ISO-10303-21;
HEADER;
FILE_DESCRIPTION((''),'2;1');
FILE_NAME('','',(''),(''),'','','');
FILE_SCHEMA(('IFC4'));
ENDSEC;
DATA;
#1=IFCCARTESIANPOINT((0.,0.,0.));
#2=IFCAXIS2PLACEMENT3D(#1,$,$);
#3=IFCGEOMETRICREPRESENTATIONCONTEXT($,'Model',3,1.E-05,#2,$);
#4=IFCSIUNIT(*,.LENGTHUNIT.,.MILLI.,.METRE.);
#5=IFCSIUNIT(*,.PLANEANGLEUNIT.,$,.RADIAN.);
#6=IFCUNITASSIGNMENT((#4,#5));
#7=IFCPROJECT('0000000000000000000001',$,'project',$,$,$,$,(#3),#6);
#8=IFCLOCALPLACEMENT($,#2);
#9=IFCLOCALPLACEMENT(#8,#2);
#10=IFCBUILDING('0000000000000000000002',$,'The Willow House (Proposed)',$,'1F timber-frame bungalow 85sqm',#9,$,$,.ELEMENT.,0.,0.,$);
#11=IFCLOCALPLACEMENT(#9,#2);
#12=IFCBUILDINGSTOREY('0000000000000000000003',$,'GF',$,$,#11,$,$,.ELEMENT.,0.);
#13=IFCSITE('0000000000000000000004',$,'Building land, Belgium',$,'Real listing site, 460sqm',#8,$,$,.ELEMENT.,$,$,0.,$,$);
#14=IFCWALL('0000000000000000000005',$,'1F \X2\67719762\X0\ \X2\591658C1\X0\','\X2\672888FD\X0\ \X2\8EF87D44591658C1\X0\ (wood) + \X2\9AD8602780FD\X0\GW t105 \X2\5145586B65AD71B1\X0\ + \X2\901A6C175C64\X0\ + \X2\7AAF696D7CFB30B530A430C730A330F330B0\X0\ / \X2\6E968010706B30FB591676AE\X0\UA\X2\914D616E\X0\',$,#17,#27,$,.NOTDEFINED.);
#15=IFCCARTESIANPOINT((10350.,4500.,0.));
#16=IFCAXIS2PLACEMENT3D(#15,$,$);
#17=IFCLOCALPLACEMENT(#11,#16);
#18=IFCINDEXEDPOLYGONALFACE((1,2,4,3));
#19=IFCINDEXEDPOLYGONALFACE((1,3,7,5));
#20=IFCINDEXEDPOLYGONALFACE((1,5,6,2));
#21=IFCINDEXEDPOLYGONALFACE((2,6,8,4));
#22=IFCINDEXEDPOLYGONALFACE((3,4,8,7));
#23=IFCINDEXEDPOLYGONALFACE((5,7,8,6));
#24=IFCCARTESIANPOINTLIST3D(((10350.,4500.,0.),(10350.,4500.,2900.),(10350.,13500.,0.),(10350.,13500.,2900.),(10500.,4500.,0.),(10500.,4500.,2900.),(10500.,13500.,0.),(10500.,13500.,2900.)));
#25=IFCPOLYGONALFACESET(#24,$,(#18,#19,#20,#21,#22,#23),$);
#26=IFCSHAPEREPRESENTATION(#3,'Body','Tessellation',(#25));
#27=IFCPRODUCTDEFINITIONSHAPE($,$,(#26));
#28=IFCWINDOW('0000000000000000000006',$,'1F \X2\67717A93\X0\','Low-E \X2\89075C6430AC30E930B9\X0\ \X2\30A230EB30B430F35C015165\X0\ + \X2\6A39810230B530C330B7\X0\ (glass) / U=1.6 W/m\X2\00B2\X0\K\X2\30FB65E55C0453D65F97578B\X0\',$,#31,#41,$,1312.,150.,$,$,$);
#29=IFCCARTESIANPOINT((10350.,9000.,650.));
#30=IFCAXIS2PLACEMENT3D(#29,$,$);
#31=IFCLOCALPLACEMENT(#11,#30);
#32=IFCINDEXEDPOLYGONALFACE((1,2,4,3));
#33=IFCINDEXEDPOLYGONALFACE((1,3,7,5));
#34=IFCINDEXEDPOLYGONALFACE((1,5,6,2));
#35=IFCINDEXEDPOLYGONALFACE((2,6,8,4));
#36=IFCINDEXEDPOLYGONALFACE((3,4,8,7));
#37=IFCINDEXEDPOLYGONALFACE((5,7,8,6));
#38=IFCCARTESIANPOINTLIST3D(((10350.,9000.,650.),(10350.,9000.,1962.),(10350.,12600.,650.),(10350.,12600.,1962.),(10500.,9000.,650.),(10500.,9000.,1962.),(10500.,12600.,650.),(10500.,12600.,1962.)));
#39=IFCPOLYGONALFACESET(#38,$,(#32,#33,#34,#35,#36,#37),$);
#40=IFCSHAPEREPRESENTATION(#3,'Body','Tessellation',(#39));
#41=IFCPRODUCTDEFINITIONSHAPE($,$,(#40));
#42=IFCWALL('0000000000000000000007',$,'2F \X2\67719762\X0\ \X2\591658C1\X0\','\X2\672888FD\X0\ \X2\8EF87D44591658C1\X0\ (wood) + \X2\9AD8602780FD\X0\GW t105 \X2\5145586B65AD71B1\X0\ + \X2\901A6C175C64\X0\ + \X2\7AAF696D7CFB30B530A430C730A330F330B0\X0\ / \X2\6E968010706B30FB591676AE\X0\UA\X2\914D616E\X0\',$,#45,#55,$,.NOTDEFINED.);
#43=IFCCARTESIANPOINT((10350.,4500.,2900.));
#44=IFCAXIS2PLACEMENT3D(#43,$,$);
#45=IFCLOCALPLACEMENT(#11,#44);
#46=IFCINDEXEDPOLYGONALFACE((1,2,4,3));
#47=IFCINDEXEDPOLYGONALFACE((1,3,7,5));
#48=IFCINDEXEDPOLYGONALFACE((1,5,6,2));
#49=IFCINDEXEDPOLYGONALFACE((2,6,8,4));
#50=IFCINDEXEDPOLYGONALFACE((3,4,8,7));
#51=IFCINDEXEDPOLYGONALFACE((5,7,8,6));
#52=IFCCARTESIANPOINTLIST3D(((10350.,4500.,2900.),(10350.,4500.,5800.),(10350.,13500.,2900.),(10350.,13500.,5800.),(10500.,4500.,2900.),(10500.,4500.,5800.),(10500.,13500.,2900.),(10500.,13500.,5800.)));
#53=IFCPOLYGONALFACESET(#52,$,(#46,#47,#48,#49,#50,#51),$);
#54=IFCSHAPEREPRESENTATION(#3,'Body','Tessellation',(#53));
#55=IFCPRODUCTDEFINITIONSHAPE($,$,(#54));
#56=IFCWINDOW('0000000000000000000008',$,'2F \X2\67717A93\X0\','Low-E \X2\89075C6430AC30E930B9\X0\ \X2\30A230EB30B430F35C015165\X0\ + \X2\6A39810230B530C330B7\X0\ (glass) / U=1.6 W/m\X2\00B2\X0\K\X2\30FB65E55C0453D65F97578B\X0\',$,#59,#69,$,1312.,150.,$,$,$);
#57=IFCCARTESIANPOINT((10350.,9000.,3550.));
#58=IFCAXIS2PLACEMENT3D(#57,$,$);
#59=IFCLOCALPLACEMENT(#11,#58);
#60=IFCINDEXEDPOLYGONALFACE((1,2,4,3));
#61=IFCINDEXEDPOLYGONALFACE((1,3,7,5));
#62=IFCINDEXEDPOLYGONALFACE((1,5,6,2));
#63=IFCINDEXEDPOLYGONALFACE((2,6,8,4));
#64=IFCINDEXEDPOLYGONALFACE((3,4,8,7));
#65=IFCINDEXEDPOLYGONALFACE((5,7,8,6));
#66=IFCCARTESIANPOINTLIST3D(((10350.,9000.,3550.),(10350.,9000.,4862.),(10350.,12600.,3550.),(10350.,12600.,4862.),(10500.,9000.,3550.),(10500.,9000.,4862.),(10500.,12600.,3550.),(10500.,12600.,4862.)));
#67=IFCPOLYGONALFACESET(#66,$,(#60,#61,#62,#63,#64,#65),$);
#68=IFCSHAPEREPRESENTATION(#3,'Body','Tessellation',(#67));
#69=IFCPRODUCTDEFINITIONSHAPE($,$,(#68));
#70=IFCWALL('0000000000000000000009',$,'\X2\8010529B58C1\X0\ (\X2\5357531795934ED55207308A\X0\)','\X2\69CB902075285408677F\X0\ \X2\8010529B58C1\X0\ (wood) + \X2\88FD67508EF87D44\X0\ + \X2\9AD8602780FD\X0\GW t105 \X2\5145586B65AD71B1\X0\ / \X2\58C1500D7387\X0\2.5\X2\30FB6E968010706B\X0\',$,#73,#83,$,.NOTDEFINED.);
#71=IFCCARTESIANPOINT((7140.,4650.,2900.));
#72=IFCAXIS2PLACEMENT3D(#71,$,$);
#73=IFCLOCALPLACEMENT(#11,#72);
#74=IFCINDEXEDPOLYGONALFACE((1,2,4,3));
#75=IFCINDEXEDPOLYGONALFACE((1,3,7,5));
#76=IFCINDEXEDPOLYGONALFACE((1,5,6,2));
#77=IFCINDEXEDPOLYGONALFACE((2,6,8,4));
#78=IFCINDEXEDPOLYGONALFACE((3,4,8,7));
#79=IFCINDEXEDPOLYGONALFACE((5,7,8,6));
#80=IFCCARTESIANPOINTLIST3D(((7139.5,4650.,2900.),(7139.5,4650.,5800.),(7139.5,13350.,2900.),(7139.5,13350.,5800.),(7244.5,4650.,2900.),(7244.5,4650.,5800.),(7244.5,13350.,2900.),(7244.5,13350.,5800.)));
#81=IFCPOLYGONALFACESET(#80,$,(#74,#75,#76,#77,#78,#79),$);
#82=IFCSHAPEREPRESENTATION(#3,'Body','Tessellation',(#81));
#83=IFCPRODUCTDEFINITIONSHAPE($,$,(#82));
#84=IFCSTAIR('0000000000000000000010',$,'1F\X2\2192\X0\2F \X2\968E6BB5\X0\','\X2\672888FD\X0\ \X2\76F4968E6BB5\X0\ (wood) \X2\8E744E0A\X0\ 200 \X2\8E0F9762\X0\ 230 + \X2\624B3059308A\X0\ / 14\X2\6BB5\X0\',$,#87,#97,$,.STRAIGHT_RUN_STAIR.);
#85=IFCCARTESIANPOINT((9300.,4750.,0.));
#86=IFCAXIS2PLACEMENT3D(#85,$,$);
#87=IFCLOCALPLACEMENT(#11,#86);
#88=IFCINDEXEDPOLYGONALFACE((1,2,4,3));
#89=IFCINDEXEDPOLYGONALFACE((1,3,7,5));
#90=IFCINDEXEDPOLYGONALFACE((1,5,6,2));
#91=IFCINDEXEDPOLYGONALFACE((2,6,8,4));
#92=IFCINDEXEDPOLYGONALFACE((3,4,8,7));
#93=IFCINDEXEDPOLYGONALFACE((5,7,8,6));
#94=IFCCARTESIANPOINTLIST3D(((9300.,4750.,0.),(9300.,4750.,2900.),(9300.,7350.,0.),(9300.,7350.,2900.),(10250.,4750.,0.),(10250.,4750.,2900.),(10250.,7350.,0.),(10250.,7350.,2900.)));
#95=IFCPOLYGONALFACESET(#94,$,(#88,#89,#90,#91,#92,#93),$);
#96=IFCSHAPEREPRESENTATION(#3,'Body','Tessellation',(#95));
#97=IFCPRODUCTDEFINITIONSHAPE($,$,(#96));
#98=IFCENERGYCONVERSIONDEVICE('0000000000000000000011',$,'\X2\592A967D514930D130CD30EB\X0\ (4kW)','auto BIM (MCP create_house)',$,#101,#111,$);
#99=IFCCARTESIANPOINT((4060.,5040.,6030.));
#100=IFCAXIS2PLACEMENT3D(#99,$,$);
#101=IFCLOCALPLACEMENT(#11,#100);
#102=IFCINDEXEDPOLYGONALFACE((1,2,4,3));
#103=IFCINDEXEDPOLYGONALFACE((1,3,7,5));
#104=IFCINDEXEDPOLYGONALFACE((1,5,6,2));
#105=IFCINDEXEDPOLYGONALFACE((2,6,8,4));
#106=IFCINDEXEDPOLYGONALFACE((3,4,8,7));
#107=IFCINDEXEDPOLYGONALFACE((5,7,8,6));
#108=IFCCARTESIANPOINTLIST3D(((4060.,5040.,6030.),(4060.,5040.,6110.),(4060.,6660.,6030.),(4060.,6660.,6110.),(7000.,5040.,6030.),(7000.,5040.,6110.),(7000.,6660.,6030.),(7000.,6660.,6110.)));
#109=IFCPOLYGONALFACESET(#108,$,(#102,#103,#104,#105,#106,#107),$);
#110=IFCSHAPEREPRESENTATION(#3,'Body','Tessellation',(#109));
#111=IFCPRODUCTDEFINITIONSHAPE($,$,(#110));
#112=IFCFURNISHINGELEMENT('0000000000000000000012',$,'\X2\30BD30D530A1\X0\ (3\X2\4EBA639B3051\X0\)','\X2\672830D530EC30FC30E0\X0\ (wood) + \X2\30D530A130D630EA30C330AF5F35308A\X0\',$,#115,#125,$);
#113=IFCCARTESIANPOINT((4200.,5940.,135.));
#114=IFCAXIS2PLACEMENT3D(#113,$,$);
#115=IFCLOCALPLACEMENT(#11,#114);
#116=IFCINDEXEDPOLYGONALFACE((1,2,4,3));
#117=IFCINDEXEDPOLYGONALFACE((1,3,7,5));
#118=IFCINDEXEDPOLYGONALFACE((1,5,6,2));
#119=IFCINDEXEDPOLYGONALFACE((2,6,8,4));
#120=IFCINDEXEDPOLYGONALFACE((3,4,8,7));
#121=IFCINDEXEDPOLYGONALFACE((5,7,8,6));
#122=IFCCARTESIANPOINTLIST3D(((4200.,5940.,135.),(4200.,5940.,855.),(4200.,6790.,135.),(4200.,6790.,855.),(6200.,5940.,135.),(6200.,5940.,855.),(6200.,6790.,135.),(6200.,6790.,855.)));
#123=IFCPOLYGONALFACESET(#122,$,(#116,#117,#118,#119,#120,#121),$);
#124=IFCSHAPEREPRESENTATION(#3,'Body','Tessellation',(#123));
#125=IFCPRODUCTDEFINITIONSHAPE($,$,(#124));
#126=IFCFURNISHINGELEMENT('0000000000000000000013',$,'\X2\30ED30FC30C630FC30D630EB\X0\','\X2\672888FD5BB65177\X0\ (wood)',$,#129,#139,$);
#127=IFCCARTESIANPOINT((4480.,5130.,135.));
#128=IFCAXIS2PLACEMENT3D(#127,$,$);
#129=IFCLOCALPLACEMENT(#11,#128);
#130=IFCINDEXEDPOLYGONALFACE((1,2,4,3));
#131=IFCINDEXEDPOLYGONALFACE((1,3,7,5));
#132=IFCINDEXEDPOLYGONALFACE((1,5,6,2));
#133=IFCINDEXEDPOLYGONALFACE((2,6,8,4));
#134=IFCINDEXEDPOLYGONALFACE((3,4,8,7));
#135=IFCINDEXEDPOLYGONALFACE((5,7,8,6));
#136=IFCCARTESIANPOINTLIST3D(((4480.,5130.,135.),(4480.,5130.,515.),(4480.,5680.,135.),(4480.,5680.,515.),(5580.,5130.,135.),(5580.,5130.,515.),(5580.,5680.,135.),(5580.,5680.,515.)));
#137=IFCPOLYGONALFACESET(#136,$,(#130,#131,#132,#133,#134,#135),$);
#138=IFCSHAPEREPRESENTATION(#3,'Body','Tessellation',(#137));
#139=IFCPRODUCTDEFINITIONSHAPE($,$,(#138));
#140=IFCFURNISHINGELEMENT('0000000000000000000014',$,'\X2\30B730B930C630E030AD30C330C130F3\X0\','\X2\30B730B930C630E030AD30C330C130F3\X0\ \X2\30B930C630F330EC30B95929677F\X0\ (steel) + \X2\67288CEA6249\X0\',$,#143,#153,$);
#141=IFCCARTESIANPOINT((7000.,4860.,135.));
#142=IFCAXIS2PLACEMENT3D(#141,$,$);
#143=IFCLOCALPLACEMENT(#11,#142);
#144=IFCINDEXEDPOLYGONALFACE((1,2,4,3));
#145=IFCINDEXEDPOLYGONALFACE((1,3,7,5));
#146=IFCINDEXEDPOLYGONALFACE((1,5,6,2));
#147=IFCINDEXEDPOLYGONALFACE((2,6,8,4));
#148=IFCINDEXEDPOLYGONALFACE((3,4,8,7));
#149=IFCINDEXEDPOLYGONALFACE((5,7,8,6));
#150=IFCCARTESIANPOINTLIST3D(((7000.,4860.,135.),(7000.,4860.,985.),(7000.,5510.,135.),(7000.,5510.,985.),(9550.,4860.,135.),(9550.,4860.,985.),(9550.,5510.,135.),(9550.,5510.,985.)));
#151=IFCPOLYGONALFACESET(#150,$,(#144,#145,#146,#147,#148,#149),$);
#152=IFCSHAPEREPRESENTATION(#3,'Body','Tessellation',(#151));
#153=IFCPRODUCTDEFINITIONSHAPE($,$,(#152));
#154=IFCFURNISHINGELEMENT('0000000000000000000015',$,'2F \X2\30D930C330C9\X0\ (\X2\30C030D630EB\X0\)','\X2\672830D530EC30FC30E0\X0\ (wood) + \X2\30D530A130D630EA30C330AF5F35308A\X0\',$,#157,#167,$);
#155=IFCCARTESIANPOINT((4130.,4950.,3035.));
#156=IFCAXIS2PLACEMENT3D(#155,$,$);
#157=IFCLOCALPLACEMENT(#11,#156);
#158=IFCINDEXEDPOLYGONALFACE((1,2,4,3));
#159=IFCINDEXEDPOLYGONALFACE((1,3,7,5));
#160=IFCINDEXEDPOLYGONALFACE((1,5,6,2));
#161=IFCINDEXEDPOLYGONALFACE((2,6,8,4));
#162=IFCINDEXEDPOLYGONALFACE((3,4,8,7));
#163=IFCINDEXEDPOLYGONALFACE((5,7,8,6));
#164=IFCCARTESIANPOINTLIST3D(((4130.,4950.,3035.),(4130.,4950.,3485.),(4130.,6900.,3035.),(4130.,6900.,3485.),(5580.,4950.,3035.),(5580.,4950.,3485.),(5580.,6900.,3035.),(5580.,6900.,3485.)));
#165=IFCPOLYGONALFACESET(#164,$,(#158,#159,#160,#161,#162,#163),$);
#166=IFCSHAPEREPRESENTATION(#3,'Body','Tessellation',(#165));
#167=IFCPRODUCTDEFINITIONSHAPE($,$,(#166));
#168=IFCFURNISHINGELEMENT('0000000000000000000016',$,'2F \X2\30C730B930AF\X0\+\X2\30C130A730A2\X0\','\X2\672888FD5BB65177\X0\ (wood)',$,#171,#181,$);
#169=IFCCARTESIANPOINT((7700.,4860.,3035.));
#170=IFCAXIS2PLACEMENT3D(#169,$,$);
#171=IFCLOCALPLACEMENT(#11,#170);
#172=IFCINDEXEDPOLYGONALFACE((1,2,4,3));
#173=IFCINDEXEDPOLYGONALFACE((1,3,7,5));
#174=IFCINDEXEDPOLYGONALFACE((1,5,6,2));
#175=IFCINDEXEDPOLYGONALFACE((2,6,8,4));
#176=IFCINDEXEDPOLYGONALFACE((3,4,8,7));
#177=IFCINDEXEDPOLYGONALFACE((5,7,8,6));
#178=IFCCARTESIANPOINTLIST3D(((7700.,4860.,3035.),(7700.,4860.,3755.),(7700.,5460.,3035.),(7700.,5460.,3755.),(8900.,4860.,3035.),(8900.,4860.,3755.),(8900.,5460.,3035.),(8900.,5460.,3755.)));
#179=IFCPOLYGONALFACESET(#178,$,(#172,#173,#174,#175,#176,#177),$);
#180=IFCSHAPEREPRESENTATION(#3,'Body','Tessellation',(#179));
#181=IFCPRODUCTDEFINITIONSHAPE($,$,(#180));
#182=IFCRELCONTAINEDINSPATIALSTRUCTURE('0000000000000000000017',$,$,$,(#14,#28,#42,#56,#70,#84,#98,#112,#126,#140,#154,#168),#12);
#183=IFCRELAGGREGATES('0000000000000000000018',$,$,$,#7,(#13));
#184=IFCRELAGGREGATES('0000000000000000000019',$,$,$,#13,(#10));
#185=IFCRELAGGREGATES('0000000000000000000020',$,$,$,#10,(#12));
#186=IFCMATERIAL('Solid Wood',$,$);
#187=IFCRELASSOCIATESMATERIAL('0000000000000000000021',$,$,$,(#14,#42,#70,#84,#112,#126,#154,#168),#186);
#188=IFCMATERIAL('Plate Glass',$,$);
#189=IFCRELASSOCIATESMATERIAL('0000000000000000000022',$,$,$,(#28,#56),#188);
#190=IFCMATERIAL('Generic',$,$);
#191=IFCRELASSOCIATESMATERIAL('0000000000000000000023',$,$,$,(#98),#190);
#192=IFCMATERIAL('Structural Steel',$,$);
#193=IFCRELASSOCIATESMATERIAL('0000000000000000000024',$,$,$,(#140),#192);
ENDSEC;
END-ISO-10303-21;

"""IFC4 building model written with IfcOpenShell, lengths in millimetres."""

from ifc_helpers import new_model, si_unit, frame, frame_2d, origin, place, context, project, spatial, rectangle, extrude, material, element, fill, save


model = new_model("IFC4")

# Units and contexts
model_context = context("Model", 3, precision=1e-05, world=origin())
ifc_project = project(units=[si_unit("LENGTHUNIT", "METRE", prefix="MILLI"), si_unit("PLANEANGLEUNIT", "RADIAN")], contexts=[model_context])

# Site, building, storey
site_placement = place(None, origin())
site = spatial("IfcSite", under=ifc_project, at=site_placement, Name="Building land, Belgium", ObjectType="Real listing site, 460sqm", CompositionType="ELEMENT", RefElevation=0.0)
building_placement = place(site_placement, origin())
building = spatial("IfcBuilding", under=site, at=building_placement, Name="The Willow House (Proposed)", ObjectType="1F timber-frame bungalow 85sqm", CompositionType="ELEMENT", ElevationOfRefHeight=0.0, ElevationOfTerrain=0.0)
storey_placement = place(building_placement, origin())
storey = spatial("IfcBuildingStorey", under=building, at=storey_placement, Name="GF", CompositionType="ELEMENT", Elevation=0.0)

# Wall, opening, window
ifc_material_1 = material(Name="Solid Wood")
wall_1_placement = place(storey_placement, frame((10350.0, 4500.0, 0.0)))
wall_1 = element("IfcWall", 1, at=wall_1_placement, inside=storey, material=ifc_material_1, Name="1F 東面 外壁", Description="木製 軸組外壁 (wood) + 高性能GW t105 充填断熱 + 通気層 + 窯業系サイディング / 準耐火・外皮UA配慮", PredefinedType="NOTDEFINED", context=model_context, shape_type="SweptSolid", body=[
    extrude(rectangle(XDim=150.0, YDim=9000.0, at=frame_2d((75.0, 4500.0))), frame((10350.0, 4500.0, 0.0)), (0.0, 0.0, 1.0), 2900.0),
])
opening_1_placement = place(storey_placement, frame((10350.0, 9000.0, 650.0)))
opening_1 = element("IfcOpeningElement", 2, at=opening_1_placement, cuts=wall_1, PredefinedType="NOTDEFINED", context=model_context, shape_type="SweptSolid", body=[
    extrude(rectangle(XDim=150.0, YDim=3600.0, at=frame_2d((75.0, 1800.0))), frame((10350.0, 9000.0, 650.0)), (0.0, 0.0, 1.0), 1312.0),
])
ifc_material_2 = material(Name="Plate Glass")
window_1_placement = place(storey_placement, frame((10350.0, 9000.0, 650.0)))
window_1 = element("IfcWindow", 3, at=window_1_placement, inside=storey, material=ifc_material_2, Name="1F 東窓", Description="Low-E 複層ガラス アルゴン封入 + 樹脂サッシ (glass) / U=1.6 W/m²K・日射取得型", OverallHeight=1312.0, OverallWidth=150.0, context=model_context, shape_type="SweptSolid", body=[
    extrude(rectangle(XDim=150.0, YDim=3600.0, at=frame_2d((75.0, 1800.0))), frame((10350.0, 9000.0, 650.0)), (0.0, 0.0, 1.0), 1312.0),
])
fill(opening_1, window_1)

# Wall, opening, window
wall_2_placement = place(storey_placement, frame((10350.0, 4500.0, 2900.0)))
wall_2 = element("IfcWall", 4, at=wall_2_placement, inside=storey, material=ifc_material_1, Name="2F 東面 外壁", Description="木製 軸組外壁 (wood) + 高性能GW t105 充填断熱 + 通気層 + 窯業系サイディング / 準耐火・外皮UA配慮", PredefinedType="NOTDEFINED", context=model_context, shape_type="SweptSolid", body=[
    extrude(rectangle(XDim=150.0, YDim=9000.0, at=frame_2d((75.0, 4500.0))), frame((10350.0, 4500.0, 2900.0)), (0.0, 0.0, 1.0), 2900.0),
])
opening_2_placement = place(storey_placement, frame((10350.0, 9000.0, 3550.0)))
opening_2 = element("IfcOpeningElement", 5, at=opening_2_placement, cuts=wall_2, PredefinedType="NOTDEFINED", context=model_context, shape_type="SweptSolid", body=[
    extrude(rectangle(XDim=150.0, YDim=3600.0, at=frame_2d((75.0, 1800.0))), frame((10350.0, 9000.0, 3550.0)), (0.0, 0.0, 1.0), 1312.0),
])
window_2_placement = place(storey_placement, frame((10350.0, 9000.0, 3550.0)))
window_2 = element("IfcWindow", 6, at=window_2_placement, inside=storey, material=ifc_material_2, Name="2F 東窓", Description="Low-E 複層ガラス アルゴン封入 + 樹脂サッシ (glass) / U=1.6 W/m²K・日射取得型", OverallHeight=1312.0, OverallWidth=150.0, context=model_context, shape_type="SweptSolid", body=[
    extrude(rectangle(XDim=150.0, YDim=3600.0, at=frame_2d((75.0, 1800.0))), frame((10350.0, 9000.0, 3550.0)), (0.0, 0.0, 1.0), 1312.0),
])
fill(opening_2, window_2)

# Wall
wall_3_placement = place(storey_placement, frame((7140.0, 4650.0, 2900.0)))
element("IfcWall", 7, at=wall_3_placement, inside=storey, material=ifc_material_1, Name="耐力壁 (南北間仕切り)", Description="構造用合板 耐力壁 (wood) + 製材軸組 + 高性能GW t105 充填断熱 / 壁倍率2.5・準耐火", PredefinedType="NOTDEFINED", context=model_context, shape_type="SweptSolid", body=[
    extrude(rectangle(XDim=105.0, YDim=8700.0, at=frame_2d((52.0, 4350.0))), frame((7140.0, 4650.0, 2900.0)), (0.0, 0.0, 1.0), 2900.0),
])

# Stair
stair_placement = place(storey_placement, frame((9300.0, 4750.0, 0.0)))
element("IfcStair", 8, at=stair_placement, inside=storey, material=ifc_material_1, Name="1F→2F 階段", Description="木製 直階段 (wood) 蹴上 200 踏面 230 + 手すり / 14段", PredefinedType="STRAIGHT_RUN_STAIR", context=model_context, shape_type="SweptSolid", body=[
    extrude(rectangle(XDim=950.0, YDim=2600.0, at=frame_2d((475.0, 1300.0))), frame((9300.0, 4750.0, 0.0)), (0.0, 0.0, 1.0), 2900.0),
])

# Energy conversion device
ifc_material_3 = material(Name="Generic")
energy_conversion_device_placement = place(storey_placement, frame((4060.0, 5040.0, 6030.0)))
element("IfcEnergyConversionDevice", 9, at=energy_conversion_device_placement, inside=storey, material=ifc_material_3, Name="太陽光パネル (4kW)", Description="auto BIM (MCP create_house)", context=model_context, shape_type="SweptSolid", body=[
    extrude(rectangle(XDim=2940.0, YDim=1620.0, at=frame_2d((1470.0, 810.0))), frame((4060.0, 5040.0, 6030.0)), (0.0, 0.0, 1.0), 80.0),
])

# Furnishing elements
furnishing_1_placement = place(storey_placement, frame((4200.0, 5940.0, 135.0)))
element("IfcFurnishingElement", 10, at=furnishing_1_placement, inside=storey, material=ifc_material_1, Name="ソファ (3人掛け)", Description="木フレーム (wood) + ファブリック張り", context=model_context, shape_type="SweptSolid", body=[
    extrude(rectangle(XDim=2000.0, YDim=850.0, at=frame_2d((1000.0, 425.0))), frame((4200.0, 5940.0, 135.0)), (0.0, 0.0, 1.0), 720.0),
])
furnishing_2_placement = place(storey_placement, frame((4480.0, 5130.0, 135.0)))
element("IfcFurnishingElement", 11, at=furnishing_2_placement, inside=storey, material=ifc_material_1, Name="ローテーブル", Description="木製家具 (wood)", context=model_context, shape_type="SweptSolid", body=[
    extrude(rectangle(XDim=1100.0, YDim=550.0, at=frame_2d((550.0, 275.0))), frame((4480.0, 5130.0, 135.0)), (0.0, 0.0, 1.0), 380.0),
])
ifc_material_4 = material(Name="Structural Steel")
furnishing_3_placement = place(storey_placement, frame((7000.0, 4860.0, 135.0)))
element("IfcFurnishingElement", 12, at=furnishing_3_placement, inside=storey, material=ifc_material_4, Name="システムキッチン", Description="システムキッチン ステンレス天板 (steel) + 木質扉", context=model_context, shape_type="SweptSolid", body=[
    extrude(rectangle(XDim=2550.0, YDim=650.0, at=frame_2d((1275.0, 325.0))), frame((7000.0, 4860.0, 135.0)), (0.0, 0.0, 1.0), 850.0),
])
furnishing_4_placement = place(storey_placement, frame((4130.0, 4950.0, 3035.0)))
element("IfcFurnishingElement", 13, at=furnishing_4_placement, inside=storey, material=ifc_material_1, Name="2F ベッド (ダブル)", Description="木フレーム (wood) + ファブリック張り", context=model_context, shape_type="SweptSolid", body=[
    extrude(rectangle(XDim=1450.0, YDim=1950.0, at=frame_2d((725.0, 975.0))), frame((4130.0, 4950.0, 3035.0)), (0.0, 0.0, 1.0), 450.0),
])
furnishing_5_placement = place(storey_placement, frame((7700.0, 4860.0, 3035.0)))
element("IfcFurnishingElement", 14, at=furnishing_5_placement, inside=storey, material=ifc_material_1, Name="2F デスク+チェア", Description="木製家具 (wood)", context=model_context, shape_type="SweptSolid", body=[
    extrude(rectangle(XDim=1200.0, YDim=600.0, at=frame_2d((600.0, 300.0))), frame((7700.0, 4860.0, 3035.0)), (0.0, 0.0, 1.0), 720.0),
])

save(model, "model.ifc")
